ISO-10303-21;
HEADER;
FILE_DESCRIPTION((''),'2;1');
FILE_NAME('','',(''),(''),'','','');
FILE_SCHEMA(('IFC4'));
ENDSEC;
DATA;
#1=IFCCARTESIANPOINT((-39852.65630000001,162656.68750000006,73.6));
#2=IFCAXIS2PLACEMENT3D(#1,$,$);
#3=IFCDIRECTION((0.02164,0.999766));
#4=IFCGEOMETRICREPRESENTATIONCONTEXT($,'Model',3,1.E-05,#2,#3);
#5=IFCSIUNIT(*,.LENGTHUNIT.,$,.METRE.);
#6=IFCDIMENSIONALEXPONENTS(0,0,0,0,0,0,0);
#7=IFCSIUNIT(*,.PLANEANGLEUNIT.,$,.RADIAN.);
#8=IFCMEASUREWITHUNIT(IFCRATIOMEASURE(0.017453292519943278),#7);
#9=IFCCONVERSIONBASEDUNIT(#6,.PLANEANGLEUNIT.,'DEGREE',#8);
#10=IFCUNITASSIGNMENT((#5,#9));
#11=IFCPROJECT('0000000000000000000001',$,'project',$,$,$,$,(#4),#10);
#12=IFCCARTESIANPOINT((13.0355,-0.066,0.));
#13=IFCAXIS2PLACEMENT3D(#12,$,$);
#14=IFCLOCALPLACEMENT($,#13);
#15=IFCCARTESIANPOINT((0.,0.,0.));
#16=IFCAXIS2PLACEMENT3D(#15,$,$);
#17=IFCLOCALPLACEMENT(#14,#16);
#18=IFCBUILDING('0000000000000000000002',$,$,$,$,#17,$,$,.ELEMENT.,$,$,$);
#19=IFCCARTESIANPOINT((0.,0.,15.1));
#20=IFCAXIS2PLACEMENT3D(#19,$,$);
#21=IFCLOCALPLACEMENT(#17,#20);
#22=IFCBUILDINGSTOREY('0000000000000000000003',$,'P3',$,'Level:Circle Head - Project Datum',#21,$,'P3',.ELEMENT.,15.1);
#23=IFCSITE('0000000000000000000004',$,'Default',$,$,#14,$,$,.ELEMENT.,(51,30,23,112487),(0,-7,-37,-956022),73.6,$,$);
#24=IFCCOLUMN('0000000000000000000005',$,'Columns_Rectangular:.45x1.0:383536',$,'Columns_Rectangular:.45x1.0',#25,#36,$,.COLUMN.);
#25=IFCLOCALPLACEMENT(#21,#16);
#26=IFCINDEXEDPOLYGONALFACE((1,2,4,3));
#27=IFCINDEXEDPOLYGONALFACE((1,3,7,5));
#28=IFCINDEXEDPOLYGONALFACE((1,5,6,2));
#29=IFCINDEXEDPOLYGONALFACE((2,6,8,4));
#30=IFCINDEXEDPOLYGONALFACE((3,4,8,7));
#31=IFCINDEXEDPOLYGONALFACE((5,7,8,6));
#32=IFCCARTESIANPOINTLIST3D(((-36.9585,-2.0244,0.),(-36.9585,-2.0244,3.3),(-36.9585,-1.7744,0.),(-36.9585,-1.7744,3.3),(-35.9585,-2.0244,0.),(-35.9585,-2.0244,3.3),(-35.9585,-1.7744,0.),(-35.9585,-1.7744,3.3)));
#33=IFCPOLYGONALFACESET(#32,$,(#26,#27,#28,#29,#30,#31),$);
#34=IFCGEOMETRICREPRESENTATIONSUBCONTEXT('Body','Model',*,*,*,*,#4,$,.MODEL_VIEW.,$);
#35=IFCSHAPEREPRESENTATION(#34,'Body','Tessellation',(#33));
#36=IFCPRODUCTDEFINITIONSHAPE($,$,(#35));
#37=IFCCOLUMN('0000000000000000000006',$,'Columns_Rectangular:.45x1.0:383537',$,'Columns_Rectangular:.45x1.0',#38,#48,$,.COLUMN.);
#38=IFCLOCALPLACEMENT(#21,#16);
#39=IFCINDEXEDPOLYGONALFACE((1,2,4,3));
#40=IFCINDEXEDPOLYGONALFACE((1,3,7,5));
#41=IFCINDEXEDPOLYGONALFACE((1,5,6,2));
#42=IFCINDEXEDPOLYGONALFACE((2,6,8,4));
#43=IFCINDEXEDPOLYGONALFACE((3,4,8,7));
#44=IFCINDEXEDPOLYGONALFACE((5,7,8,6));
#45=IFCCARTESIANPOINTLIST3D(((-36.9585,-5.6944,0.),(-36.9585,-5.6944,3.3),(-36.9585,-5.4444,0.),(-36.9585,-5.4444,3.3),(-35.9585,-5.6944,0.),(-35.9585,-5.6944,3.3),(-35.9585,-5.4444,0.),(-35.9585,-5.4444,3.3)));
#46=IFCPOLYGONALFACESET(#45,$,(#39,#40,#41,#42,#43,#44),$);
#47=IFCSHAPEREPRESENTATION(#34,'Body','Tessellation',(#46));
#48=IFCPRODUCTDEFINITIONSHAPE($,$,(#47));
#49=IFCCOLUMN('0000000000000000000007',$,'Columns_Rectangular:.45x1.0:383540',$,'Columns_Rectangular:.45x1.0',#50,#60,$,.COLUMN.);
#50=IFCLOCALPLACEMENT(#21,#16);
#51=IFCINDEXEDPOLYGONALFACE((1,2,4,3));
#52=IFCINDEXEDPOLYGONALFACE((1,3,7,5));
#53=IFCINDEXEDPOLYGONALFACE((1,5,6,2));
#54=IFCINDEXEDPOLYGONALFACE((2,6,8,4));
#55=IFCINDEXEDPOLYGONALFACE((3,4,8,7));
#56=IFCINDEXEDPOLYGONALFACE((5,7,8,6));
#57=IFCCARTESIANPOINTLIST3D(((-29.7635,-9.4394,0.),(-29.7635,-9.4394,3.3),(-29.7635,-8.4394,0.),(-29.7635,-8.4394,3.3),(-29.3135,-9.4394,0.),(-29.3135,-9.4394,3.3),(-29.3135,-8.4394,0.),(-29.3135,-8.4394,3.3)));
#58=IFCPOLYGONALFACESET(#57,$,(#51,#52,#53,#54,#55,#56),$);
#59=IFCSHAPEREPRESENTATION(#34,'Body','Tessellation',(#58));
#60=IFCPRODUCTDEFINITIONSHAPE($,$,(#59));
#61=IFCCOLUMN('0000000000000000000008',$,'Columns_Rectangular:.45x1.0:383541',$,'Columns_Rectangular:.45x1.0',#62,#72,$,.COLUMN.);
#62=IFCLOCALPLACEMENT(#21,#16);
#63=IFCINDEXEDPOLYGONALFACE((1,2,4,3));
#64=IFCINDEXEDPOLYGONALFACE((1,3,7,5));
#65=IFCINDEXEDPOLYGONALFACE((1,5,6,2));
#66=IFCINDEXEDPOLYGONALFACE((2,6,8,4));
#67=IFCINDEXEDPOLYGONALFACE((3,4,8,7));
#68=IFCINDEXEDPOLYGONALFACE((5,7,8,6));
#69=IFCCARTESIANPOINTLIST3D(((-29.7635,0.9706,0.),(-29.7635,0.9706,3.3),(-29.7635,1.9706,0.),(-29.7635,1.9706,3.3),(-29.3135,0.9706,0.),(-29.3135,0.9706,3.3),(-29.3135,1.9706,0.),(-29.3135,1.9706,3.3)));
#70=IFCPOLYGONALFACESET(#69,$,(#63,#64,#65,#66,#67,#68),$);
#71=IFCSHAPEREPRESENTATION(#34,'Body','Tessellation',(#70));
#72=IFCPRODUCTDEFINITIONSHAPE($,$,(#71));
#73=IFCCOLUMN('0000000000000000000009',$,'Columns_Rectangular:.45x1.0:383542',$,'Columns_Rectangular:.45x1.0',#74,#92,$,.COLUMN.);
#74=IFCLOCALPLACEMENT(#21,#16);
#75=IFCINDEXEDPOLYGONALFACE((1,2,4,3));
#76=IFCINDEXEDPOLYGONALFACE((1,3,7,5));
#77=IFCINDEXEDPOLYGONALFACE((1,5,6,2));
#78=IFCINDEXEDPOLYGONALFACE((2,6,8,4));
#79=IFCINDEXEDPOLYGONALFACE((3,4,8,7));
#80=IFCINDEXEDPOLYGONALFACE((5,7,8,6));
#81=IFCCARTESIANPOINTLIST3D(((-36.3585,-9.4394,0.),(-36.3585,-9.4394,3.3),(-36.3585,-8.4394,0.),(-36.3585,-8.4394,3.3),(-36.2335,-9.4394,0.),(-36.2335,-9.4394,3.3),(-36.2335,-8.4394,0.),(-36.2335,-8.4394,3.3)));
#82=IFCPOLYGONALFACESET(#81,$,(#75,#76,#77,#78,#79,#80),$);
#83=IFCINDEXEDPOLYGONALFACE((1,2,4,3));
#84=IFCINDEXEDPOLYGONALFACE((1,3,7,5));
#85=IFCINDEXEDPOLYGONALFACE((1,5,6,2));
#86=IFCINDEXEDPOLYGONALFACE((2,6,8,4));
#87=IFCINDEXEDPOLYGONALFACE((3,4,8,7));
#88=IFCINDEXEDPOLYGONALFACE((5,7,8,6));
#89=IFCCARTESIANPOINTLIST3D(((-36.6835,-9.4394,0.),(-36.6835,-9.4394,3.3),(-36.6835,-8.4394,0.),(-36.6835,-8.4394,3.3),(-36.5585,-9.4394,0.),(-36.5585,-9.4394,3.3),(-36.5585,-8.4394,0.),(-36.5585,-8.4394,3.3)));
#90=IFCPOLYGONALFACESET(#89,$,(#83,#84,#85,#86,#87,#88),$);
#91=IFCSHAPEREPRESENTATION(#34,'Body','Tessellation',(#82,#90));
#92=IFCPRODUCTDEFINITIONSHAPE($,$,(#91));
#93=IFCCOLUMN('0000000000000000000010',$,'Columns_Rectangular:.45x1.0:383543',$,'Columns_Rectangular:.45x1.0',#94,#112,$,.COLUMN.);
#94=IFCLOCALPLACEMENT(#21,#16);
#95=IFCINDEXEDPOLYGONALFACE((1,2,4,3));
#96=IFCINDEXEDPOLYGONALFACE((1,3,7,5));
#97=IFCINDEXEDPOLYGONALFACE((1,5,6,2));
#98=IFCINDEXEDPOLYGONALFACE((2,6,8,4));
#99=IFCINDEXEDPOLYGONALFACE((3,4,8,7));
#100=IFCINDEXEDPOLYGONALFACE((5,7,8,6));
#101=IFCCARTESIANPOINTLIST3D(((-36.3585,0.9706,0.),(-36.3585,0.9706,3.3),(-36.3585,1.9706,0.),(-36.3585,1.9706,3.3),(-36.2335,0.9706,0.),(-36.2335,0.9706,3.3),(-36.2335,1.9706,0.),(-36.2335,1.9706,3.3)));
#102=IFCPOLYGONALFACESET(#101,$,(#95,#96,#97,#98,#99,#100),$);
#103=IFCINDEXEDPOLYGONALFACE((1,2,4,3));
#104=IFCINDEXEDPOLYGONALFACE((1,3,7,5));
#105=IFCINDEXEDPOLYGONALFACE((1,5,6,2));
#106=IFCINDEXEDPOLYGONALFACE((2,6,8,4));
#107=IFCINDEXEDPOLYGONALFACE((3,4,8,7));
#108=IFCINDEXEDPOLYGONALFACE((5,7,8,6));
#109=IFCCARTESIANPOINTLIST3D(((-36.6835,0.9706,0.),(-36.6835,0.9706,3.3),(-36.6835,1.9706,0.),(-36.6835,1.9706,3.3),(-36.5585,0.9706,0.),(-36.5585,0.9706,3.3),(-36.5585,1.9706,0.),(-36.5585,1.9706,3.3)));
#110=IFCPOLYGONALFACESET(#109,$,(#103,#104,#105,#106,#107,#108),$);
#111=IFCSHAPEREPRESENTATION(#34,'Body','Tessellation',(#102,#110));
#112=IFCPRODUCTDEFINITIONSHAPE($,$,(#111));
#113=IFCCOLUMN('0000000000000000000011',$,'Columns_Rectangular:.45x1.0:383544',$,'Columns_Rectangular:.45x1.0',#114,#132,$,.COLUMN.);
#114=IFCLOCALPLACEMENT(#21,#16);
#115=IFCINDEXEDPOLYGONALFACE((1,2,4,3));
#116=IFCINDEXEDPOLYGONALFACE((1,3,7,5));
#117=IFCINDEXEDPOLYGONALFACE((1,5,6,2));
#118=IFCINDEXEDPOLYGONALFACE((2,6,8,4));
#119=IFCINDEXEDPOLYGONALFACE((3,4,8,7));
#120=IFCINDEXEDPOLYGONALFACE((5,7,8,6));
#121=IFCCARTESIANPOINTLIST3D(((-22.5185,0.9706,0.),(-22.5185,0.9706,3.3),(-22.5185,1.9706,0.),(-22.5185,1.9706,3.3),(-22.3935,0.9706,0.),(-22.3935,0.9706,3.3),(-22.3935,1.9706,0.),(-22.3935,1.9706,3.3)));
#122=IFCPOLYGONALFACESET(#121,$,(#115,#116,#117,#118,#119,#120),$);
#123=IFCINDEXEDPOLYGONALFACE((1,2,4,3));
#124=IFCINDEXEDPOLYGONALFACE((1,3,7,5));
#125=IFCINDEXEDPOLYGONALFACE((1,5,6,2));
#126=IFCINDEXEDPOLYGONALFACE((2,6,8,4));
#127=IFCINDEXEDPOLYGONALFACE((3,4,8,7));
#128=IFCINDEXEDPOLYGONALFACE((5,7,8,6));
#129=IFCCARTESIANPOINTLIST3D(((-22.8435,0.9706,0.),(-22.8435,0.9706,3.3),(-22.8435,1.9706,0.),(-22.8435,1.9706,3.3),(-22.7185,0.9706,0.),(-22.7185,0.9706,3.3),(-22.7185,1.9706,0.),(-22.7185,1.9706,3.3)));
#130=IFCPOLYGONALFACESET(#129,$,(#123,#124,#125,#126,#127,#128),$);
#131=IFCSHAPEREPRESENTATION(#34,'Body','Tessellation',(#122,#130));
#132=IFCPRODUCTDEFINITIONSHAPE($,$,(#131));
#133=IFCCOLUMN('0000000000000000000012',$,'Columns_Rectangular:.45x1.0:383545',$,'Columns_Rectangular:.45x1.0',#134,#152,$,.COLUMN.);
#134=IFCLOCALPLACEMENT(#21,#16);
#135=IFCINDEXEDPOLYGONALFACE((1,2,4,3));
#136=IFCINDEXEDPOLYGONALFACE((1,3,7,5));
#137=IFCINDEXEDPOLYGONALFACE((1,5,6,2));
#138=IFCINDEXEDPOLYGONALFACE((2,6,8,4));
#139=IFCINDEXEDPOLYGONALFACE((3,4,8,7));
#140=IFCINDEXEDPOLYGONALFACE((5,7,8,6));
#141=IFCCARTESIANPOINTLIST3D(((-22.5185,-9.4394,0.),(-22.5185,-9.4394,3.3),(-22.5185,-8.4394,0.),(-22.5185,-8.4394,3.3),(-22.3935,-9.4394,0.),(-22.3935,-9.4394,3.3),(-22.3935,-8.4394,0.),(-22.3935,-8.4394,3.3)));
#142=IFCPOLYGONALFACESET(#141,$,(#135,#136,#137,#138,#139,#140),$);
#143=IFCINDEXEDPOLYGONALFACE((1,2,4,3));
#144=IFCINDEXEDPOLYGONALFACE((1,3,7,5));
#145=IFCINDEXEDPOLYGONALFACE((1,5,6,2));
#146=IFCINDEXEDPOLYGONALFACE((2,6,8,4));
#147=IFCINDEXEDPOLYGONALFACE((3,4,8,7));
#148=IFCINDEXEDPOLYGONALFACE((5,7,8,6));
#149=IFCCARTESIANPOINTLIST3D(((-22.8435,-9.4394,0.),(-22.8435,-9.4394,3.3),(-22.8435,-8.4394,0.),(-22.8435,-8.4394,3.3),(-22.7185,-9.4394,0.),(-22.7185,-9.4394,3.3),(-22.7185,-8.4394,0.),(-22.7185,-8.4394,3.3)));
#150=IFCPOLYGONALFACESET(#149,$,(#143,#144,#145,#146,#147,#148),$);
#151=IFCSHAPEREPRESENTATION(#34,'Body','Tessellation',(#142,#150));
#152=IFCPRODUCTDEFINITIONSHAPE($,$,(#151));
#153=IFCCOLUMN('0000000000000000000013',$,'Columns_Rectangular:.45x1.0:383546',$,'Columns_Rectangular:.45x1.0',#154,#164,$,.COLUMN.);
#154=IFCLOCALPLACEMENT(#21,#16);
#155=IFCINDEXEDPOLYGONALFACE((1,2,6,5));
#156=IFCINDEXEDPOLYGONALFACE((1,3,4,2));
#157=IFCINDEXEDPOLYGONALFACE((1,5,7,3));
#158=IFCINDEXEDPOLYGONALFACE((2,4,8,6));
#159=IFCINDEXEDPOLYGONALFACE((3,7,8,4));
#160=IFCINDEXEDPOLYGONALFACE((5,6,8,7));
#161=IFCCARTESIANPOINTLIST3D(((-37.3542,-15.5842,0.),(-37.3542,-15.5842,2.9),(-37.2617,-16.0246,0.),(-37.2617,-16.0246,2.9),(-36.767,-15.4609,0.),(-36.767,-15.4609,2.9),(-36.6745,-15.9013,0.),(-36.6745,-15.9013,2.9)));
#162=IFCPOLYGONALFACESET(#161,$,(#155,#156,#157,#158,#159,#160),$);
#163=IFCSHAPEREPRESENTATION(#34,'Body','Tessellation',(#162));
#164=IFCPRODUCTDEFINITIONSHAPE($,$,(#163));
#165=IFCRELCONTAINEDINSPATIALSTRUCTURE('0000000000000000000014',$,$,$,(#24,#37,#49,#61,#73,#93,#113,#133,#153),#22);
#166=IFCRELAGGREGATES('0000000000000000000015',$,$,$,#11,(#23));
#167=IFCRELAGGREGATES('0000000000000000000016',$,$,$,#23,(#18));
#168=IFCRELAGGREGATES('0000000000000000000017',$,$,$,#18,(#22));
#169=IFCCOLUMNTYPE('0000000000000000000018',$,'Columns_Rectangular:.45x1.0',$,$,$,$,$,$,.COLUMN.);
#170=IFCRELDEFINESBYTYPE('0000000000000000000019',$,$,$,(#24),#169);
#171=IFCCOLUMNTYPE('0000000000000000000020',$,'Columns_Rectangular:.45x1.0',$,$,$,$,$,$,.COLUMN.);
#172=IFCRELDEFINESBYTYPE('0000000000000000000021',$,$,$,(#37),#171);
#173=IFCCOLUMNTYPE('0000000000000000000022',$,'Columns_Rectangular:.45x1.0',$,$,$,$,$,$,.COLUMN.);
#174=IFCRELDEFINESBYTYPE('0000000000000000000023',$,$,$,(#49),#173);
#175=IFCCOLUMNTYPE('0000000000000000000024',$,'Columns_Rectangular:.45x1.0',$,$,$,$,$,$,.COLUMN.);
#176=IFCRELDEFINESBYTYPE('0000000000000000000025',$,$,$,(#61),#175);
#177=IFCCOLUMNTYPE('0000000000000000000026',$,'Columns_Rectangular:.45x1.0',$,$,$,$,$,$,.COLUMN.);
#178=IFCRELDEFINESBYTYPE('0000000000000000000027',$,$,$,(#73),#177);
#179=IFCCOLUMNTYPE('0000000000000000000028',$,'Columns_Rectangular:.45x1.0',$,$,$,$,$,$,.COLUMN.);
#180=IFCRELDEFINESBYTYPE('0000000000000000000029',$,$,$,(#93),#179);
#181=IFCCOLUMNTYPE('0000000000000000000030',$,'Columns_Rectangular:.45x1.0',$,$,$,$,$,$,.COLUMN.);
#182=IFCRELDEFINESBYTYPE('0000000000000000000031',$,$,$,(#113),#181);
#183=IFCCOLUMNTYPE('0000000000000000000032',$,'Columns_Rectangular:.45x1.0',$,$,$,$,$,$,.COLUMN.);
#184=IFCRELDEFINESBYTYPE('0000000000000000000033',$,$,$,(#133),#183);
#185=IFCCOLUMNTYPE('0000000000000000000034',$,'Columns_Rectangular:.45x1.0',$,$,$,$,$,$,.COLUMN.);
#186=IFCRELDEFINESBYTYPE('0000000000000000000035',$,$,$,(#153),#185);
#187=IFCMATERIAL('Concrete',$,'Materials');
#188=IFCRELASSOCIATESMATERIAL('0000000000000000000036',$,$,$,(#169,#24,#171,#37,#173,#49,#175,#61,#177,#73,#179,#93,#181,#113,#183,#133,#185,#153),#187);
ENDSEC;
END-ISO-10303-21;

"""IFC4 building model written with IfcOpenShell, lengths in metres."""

from ifc_helpers import new_model, entity, si_unit, converted_unit, direction, frame, origin, place, context, subcontext, project, spatial, indexed_curve, outline, extrude, source, transform, mapped, material, type_object, type_shapes, element, save


model = new_model("IFC4")

# Units and contexts
model_context = context("Model", 3, precision=1e-05, world=frame((-39852.65630000001, 162656.68750000006, 73.6)), true_north=direction((0.02164, 0.999766)))
body_context = subcontext(model_context, "Body", "Model", "MODEL_VIEW")
ifc_project = project(units=[si_unit("LENGTHUNIT", "METRE"), converted_unit("PLANEANGLEUNIT", "DEGREE", entity("IfcRatioMeasure", 0.017453292519943278), si_unit("PLANEANGLEUNIT", "RADIAN"), dimensions=[0, 0, 0, 0, 0, 0, 0])], contexts=[model_context])

# Site, building, storey
site_placement = place(None, frame((13.0355, -0.066, 0.0)))
site = spatial("IfcSite", under=ifc_project, at=site_placement, Name="Default", CompositionType="ELEMENT", RefLatitude=(51, 30, 23, 112487), RefLongitude=(0, -7, -37, -956022), RefElevation=73.6)
building_placement = place(site_placement, origin())
building = spatial("IfcBuilding", under=site, at=building_placement, CompositionType="ELEMENT")
storey_placement = place(building_placement, frame((0.0, 0.0, 15.1)))
storey = spatial("IfcBuildingStorey", under=building, at=storey_placement, Name="P3", ObjectType="Level:Circle Head - Project Datum", LongName="P3", CompositionType="ELEMENT", Elevation=15.1)

# Columns
ifc_material = material(Name="Concrete", Category="Materials")
column_type_1 = type_object("IfcColumnType", Name="Columns_Rectangular:.45x1.0", PredefinedType="COLUMN", material=ifc_material)
shared_shape_1 = source(origin(), body_context, "Body", "SweptSolid", [
    extrude(outline(indexed_curve([(-0.125, -0.5), (0.125, -0.5), (0.125, 0.5), (-0.125, 0.5), (-0.125, -0.5)], self_intersect=False)), frame((-36.4585, -1.8994, 15.1), z_axis=(0.0, 0.0, 1.0), x_axis=(0.0, -1.0, 0.0)), (0.0, 0.0, 1.0), 3.3),
])
type_shapes(column_type_1, [shared_shape_1])
column_1_placement = place(storey_placement, frame((0.0, 0.0, -15.1)))
element("IfcColumn", 1, at=column_1_placement, inside=storey, type_object=column_type_1, material=ifc_material, Name="Columns_Rectangular:.45x1.0:383536", ObjectType="Columns_Rectangular:.45x1.0", PredefinedType="COLUMN", context=body_context, shape_type="MappedRepresentation", body=[
    mapped(shared_shape_1, transform((0.0, 0.0, 0.0), scale=1.0)),
])
column_type_2 = type_object("IfcColumnType", Name="Columns_Rectangular:.45x1.0", PredefinedType="COLUMN", material=ifc_material)
shared_shape_2 = source(origin(), body_context, "Body", "SweptSolid", [
    extrude(outline(indexed_curve([(-0.125, -0.5), (0.125, -0.5), (0.125, 0.5), (-0.125, 0.5), (-0.125, -0.5)], self_intersect=False)), frame((-36.4585, -5.5694, 15.1), z_axis=(0.0, 0.0, 1.0), x_axis=(0.0, -1.0, 0.0)), (0.0, 0.0, 1.0), 3.3),
])
type_shapes(column_type_2, [shared_shape_2])
column_2_placement = place(storey_placement, frame((0.0, 0.0, -15.1)))
element("IfcColumn", 2, at=column_2_placement, inside=storey, type_object=column_type_2, material=ifc_material, Name="Columns_Rectangular:.45x1.0:383537", ObjectType="Columns_Rectangular:.45x1.0", PredefinedType="COLUMN", context=body_context, shape_type="MappedRepresentation", body=[
    mapped(shared_shape_2, transform((0.0, 0.0, 0.0), scale=1.0)),
])
column_type_3 = type_object("IfcColumnType", Name="Columns_Rectangular:.45x1.0", PredefinedType="COLUMN", material=ifc_material)
shared_shape_3 = source(origin(), body_context, "Body", "SweptSolid", [
    extrude(outline(indexed_curve([(-0.5, -0.225), (0.5, -0.225), (0.5, 0.225), (-0.5, 0.225), (-0.5, -0.225)], self_intersect=False)), frame((-29.5385, -8.9394, 15.1), z_axis=(0.0, 0.0, 1.0), x_axis=(0.0, -1.0, 0.0)), (0.0, 0.0, 1.0), 3.3),
])
type_shapes(column_type_3, [shared_shape_3])
column_3_placement = place(storey_placement, frame((0.0, 0.0, -15.1)))
element("IfcColumn", 3, at=column_3_placement, inside=storey, type_object=column_type_3, material=ifc_material, Name="Columns_Rectangular:.45x1.0:383540", ObjectType="Columns_Rectangular:.45x1.0", PredefinedType="COLUMN", context=body_context, shape_type="MappedRepresentation", body=[
    mapped(shared_shape_3, transform((0.0, 0.0, 0.0), scale=1.0)),
])
column_type_4 = type_object("IfcColumnType", Name="Columns_Rectangular:.45x1.0", PredefinedType="COLUMN", material=ifc_material)
shared_shape_4 = source(origin(), body_context, "Body", "SweptSolid", [
    extrude(outline(indexed_curve([(-0.5, -0.225), (0.5, -0.225), (0.5, 0.225), (-0.5, 0.225), (-0.5, -0.225)], self_intersect=False)), frame((-29.5385, 1.4706, 15.1), z_axis=(0.0, 0.0, 1.0), x_axis=(0.0, -1.0, 0.0)), (0.0, 0.0, 1.0), 3.3),
])
type_shapes(column_type_4, [shared_shape_4])
column_4_placement = place(storey_placement, frame((0.0, 0.0, -15.1)))
element("IfcColumn", 4, at=column_4_placement, inside=storey, type_object=column_type_4, material=ifc_material, Name="Columns_Rectangular:.45x1.0:383541", ObjectType="Columns_Rectangular:.45x1.0", PredefinedType="COLUMN", context=body_context, shape_type="MappedRepresentation", body=[
    mapped(shared_shape_4, transform((0.0, 0.0, 0.0), scale=1.0)),
])
column_type_5 = type_object("IfcColumnType", Name="Columns_Rectangular:.45x1.0", PredefinedType="COLUMN", material=ifc_material)
shared_shape_5 = source(origin(), body_context, "Body", "SweptSolid", [
    extrude(outline(indexed_curve([(-0.5, -0.0625), (0.5, -0.0625), (0.5, 0.0625), (-0.5, 0.0625), (-0.5, -0.0625)], self_intersect=False)), frame((-36.296, -8.9394, 15.1), z_axis=(0.0, 0.0, 1.0), x_axis=(0.0, -1.0, 0.0)), (0.0, 0.0, 1.0), 3.3),
    extrude(outline(indexed_curve([(-0.5, -0.0625), (0.5, -0.0625), (0.5, 0.0625), (-0.5, 0.0625), (-0.5, -0.0625)], self_intersect=False)), frame((-36.621, -8.9394, 15.1), z_axis=(0.0, 0.0, 1.0), x_axis=(0.0, -1.0, 0.0)), (0.0, 0.0, 1.0), 3.3),
])
type_shapes(column_type_5, [shared_shape_5])
column_5_placement = place(storey_placement, frame((0.0, 0.0, -15.1)))
element("IfcColumn", 5, at=column_5_placement, inside=storey, type_object=column_type_5, material=ifc_material, Name="Columns_Rectangular:.45x1.0:383542", ObjectType="Columns_Rectangular:.45x1.0", PredefinedType="COLUMN", context=body_context, shape_type="MappedRepresentation", body=[
    mapped(shared_shape_5, transform((0.0, 0.0, 0.0), scale=1.0)),
])
column_type_6 = type_object("IfcColumnType", Name="Columns_Rectangular:.45x1.0", PredefinedType="COLUMN", material=ifc_material)
shared_shape_6 = source(origin(), body_context, "Body", "SweptSolid", [
    extrude(outline(indexed_curve([(-0.5, -0.0625), (0.5, -0.0625), (0.5, 0.0625), (-0.5, 0.0625), (-0.5, -0.0625)], self_intersect=False)), frame((-36.296, 1.4706, 15.1), z_axis=(0.0, 0.0, 1.0), x_axis=(0.0, -1.0, 0.0)), (0.0, 0.0, 1.0), 3.3),
    extrude(outline(indexed_curve([(-0.5, -0.0625), (0.5, -0.0625), (0.5, 0.0625), (-0.5, 0.0625), (-0.5, -0.0625)], self_intersect=False)), frame((-36.621, 1.4706, 15.1), z_axis=(0.0, 0.0, 1.0), x_axis=(0.0, -1.0, 0.0)), (0.0, 0.0, 1.0), 3.3),
])
type_shapes(column_type_6, [shared_shape_6])
column_6_placement = place(storey_placement, frame((0.0, 0.0, -15.1)))
element("IfcColumn", 6, at=column_6_placement, inside=storey, type_object=column_type_6, material=ifc_material, Name="Columns_Rectangular:.45x1.0:383543", ObjectType="Columns_Rectangular:.45x1.0", PredefinedType="COLUMN", context=body_context, shape_type="MappedRepresentation", body=[
    mapped(shared_shape_6, transform((0.0, 0.0, 0.0), scale=1.0)),
])
column_type_7 = type_object("IfcColumnType", Name="Columns_Rectangular:.45x1.0", PredefinedType="COLUMN", material=ifc_material)
shared_shape_7 = source(origin(), body_context, "Body", "SweptSolid", [
    extrude(outline(indexed_curve([(-0.5, -0.0625), (0.5, -0.0625), (0.5, 0.0625), (-0.5, 0.0625), (-0.5, -0.0625)], self_intersect=False)), frame((-22.456, 1.4706, 15.1), z_axis=(0.0, 0.0, 1.0), x_axis=(0.0, -1.0, 0.0)), (0.0, 0.0, 1.0), 3.3),
    extrude(outline(indexed_curve([(-0.5, -0.0625), (0.5, -0.0625), (0.5, 0.0625), (-0.5, 0.0625), (-0.5, -0.0625)], self_intersect=False)), frame((-22.781, 1.4706, 15.1), z_axis=(0.0, 0.0, 1.0), x_axis=(0.0, -1.0, 0.0)), (0.0, 0.0, 1.0), 3.3),
])
type_shapes(column_type_7, [shared_shape_7])
column_7_placement = place(storey_placement, frame((0.0, 0.0, -15.1)))
element("IfcColumn", 7, at=column_7_placement, inside=storey, type_object=column_type_7, material=ifc_material, Name="Columns_Rectangular:.45x1.0:383544", ObjectType="Columns_Rectangular:.45x1.0", PredefinedType="COLUMN", context=body_context, shape_type="MappedRepresentation", body=[
    mapped(shared_shape_7, transform((0.0, 0.0, 0.0), scale=1.0)),
])
column_type_8 = type_object("IfcColumnType", Name="Columns_Rectangular:.45x1.0", PredefinedType="COLUMN", material=ifc_material)
shared_shape_8 = source(origin(), body_context, "Body", "SweptSolid", [
    extrude(outline(indexed_curve([(-0.5, -0.0625), (0.5, -0.0625), (0.5, 0.0625), (-0.5, 0.0625), (-0.5, -0.0625)], self_intersect=False)), frame((-22.456, -8.9394, 15.1), z_axis=(0.0, 0.0, 1.0), x_axis=(0.0, -1.0, 0.0)), (0.0, 0.0, 1.0), 3.3),
    extrude(outline(indexed_curve([(-0.5, -0.0625), (0.5, -0.0625), (0.5, 0.0625), (-0.5, 0.0625), (-0.5, -0.0625)], self_intersect=False)), frame((-22.781, -8.9394, 15.1), z_axis=(0.0, 0.0, 1.0), x_axis=(0.0, -1.0, 0.0)), (0.0, 0.0, 1.0), 3.3),
])
type_shapes(column_type_8, [shared_shape_8])
column_8_placement = place(storey_placement, frame((0.0, 0.0, -15.1)))
element("IfcColumn", 8, at=column_8_placement, inside=storey, type_object=column_type_8, material=ifc_material, Name="Columns_Rectangular:.45x1.0:383545", ObjectType="Columns_Rectangular:.45x1.0", PredefinedType="COLUMN", context=body_context, shape_type="MappedRepresentation", body=[
    mapped(shared_shape_8, transform((0.0, 0.0, 0.0), scale=1.0)),
])
column_type_9 = type_object("IfcColumnType", Name="Columns_Rectangular:.45x1.0", PredefinedType="COLUMN", material=ifc_material)
shared_shape_9 = source(origin(), body_context, "Body", "SweptSolid", [
    extrude(outline(indexed_curve([(-0.3, -0.225), (0.3, -0.225), (0.3, 0.225), (-0.3, 0.225), (-0.3, -0.225)], self_intersect=False)), frame((-37.0144, -15.7427, 15.1), z_axis=(0.0, 0.0, 1.0), x_axis=(-0.978657, -0.2055, 0.0)), (0.0, 0.0, 1.0), 2.9),
])
type_shapes(column_type_9, [shared_shape_9])
column_9_placement = place(storey_placement, frame((0.0, 0.0, -15.1)))
element("IfcColumn", 9, at=column_9_placement, inside=storey, type_object=column_type_9, material=ifc_material, Name="Columns_Rectangular:.45x1.0:383546", ObjectType="Columns_Rectangular:.45x1.0", PredefinedType="COLUMN", context=body_context, shape_type="MappedRepresentation", body=[
    mapped(shared_shape_9, transform((0.0, 0.0, 0.0), scale=1.0)),
])

save(model, "model.ifc")
